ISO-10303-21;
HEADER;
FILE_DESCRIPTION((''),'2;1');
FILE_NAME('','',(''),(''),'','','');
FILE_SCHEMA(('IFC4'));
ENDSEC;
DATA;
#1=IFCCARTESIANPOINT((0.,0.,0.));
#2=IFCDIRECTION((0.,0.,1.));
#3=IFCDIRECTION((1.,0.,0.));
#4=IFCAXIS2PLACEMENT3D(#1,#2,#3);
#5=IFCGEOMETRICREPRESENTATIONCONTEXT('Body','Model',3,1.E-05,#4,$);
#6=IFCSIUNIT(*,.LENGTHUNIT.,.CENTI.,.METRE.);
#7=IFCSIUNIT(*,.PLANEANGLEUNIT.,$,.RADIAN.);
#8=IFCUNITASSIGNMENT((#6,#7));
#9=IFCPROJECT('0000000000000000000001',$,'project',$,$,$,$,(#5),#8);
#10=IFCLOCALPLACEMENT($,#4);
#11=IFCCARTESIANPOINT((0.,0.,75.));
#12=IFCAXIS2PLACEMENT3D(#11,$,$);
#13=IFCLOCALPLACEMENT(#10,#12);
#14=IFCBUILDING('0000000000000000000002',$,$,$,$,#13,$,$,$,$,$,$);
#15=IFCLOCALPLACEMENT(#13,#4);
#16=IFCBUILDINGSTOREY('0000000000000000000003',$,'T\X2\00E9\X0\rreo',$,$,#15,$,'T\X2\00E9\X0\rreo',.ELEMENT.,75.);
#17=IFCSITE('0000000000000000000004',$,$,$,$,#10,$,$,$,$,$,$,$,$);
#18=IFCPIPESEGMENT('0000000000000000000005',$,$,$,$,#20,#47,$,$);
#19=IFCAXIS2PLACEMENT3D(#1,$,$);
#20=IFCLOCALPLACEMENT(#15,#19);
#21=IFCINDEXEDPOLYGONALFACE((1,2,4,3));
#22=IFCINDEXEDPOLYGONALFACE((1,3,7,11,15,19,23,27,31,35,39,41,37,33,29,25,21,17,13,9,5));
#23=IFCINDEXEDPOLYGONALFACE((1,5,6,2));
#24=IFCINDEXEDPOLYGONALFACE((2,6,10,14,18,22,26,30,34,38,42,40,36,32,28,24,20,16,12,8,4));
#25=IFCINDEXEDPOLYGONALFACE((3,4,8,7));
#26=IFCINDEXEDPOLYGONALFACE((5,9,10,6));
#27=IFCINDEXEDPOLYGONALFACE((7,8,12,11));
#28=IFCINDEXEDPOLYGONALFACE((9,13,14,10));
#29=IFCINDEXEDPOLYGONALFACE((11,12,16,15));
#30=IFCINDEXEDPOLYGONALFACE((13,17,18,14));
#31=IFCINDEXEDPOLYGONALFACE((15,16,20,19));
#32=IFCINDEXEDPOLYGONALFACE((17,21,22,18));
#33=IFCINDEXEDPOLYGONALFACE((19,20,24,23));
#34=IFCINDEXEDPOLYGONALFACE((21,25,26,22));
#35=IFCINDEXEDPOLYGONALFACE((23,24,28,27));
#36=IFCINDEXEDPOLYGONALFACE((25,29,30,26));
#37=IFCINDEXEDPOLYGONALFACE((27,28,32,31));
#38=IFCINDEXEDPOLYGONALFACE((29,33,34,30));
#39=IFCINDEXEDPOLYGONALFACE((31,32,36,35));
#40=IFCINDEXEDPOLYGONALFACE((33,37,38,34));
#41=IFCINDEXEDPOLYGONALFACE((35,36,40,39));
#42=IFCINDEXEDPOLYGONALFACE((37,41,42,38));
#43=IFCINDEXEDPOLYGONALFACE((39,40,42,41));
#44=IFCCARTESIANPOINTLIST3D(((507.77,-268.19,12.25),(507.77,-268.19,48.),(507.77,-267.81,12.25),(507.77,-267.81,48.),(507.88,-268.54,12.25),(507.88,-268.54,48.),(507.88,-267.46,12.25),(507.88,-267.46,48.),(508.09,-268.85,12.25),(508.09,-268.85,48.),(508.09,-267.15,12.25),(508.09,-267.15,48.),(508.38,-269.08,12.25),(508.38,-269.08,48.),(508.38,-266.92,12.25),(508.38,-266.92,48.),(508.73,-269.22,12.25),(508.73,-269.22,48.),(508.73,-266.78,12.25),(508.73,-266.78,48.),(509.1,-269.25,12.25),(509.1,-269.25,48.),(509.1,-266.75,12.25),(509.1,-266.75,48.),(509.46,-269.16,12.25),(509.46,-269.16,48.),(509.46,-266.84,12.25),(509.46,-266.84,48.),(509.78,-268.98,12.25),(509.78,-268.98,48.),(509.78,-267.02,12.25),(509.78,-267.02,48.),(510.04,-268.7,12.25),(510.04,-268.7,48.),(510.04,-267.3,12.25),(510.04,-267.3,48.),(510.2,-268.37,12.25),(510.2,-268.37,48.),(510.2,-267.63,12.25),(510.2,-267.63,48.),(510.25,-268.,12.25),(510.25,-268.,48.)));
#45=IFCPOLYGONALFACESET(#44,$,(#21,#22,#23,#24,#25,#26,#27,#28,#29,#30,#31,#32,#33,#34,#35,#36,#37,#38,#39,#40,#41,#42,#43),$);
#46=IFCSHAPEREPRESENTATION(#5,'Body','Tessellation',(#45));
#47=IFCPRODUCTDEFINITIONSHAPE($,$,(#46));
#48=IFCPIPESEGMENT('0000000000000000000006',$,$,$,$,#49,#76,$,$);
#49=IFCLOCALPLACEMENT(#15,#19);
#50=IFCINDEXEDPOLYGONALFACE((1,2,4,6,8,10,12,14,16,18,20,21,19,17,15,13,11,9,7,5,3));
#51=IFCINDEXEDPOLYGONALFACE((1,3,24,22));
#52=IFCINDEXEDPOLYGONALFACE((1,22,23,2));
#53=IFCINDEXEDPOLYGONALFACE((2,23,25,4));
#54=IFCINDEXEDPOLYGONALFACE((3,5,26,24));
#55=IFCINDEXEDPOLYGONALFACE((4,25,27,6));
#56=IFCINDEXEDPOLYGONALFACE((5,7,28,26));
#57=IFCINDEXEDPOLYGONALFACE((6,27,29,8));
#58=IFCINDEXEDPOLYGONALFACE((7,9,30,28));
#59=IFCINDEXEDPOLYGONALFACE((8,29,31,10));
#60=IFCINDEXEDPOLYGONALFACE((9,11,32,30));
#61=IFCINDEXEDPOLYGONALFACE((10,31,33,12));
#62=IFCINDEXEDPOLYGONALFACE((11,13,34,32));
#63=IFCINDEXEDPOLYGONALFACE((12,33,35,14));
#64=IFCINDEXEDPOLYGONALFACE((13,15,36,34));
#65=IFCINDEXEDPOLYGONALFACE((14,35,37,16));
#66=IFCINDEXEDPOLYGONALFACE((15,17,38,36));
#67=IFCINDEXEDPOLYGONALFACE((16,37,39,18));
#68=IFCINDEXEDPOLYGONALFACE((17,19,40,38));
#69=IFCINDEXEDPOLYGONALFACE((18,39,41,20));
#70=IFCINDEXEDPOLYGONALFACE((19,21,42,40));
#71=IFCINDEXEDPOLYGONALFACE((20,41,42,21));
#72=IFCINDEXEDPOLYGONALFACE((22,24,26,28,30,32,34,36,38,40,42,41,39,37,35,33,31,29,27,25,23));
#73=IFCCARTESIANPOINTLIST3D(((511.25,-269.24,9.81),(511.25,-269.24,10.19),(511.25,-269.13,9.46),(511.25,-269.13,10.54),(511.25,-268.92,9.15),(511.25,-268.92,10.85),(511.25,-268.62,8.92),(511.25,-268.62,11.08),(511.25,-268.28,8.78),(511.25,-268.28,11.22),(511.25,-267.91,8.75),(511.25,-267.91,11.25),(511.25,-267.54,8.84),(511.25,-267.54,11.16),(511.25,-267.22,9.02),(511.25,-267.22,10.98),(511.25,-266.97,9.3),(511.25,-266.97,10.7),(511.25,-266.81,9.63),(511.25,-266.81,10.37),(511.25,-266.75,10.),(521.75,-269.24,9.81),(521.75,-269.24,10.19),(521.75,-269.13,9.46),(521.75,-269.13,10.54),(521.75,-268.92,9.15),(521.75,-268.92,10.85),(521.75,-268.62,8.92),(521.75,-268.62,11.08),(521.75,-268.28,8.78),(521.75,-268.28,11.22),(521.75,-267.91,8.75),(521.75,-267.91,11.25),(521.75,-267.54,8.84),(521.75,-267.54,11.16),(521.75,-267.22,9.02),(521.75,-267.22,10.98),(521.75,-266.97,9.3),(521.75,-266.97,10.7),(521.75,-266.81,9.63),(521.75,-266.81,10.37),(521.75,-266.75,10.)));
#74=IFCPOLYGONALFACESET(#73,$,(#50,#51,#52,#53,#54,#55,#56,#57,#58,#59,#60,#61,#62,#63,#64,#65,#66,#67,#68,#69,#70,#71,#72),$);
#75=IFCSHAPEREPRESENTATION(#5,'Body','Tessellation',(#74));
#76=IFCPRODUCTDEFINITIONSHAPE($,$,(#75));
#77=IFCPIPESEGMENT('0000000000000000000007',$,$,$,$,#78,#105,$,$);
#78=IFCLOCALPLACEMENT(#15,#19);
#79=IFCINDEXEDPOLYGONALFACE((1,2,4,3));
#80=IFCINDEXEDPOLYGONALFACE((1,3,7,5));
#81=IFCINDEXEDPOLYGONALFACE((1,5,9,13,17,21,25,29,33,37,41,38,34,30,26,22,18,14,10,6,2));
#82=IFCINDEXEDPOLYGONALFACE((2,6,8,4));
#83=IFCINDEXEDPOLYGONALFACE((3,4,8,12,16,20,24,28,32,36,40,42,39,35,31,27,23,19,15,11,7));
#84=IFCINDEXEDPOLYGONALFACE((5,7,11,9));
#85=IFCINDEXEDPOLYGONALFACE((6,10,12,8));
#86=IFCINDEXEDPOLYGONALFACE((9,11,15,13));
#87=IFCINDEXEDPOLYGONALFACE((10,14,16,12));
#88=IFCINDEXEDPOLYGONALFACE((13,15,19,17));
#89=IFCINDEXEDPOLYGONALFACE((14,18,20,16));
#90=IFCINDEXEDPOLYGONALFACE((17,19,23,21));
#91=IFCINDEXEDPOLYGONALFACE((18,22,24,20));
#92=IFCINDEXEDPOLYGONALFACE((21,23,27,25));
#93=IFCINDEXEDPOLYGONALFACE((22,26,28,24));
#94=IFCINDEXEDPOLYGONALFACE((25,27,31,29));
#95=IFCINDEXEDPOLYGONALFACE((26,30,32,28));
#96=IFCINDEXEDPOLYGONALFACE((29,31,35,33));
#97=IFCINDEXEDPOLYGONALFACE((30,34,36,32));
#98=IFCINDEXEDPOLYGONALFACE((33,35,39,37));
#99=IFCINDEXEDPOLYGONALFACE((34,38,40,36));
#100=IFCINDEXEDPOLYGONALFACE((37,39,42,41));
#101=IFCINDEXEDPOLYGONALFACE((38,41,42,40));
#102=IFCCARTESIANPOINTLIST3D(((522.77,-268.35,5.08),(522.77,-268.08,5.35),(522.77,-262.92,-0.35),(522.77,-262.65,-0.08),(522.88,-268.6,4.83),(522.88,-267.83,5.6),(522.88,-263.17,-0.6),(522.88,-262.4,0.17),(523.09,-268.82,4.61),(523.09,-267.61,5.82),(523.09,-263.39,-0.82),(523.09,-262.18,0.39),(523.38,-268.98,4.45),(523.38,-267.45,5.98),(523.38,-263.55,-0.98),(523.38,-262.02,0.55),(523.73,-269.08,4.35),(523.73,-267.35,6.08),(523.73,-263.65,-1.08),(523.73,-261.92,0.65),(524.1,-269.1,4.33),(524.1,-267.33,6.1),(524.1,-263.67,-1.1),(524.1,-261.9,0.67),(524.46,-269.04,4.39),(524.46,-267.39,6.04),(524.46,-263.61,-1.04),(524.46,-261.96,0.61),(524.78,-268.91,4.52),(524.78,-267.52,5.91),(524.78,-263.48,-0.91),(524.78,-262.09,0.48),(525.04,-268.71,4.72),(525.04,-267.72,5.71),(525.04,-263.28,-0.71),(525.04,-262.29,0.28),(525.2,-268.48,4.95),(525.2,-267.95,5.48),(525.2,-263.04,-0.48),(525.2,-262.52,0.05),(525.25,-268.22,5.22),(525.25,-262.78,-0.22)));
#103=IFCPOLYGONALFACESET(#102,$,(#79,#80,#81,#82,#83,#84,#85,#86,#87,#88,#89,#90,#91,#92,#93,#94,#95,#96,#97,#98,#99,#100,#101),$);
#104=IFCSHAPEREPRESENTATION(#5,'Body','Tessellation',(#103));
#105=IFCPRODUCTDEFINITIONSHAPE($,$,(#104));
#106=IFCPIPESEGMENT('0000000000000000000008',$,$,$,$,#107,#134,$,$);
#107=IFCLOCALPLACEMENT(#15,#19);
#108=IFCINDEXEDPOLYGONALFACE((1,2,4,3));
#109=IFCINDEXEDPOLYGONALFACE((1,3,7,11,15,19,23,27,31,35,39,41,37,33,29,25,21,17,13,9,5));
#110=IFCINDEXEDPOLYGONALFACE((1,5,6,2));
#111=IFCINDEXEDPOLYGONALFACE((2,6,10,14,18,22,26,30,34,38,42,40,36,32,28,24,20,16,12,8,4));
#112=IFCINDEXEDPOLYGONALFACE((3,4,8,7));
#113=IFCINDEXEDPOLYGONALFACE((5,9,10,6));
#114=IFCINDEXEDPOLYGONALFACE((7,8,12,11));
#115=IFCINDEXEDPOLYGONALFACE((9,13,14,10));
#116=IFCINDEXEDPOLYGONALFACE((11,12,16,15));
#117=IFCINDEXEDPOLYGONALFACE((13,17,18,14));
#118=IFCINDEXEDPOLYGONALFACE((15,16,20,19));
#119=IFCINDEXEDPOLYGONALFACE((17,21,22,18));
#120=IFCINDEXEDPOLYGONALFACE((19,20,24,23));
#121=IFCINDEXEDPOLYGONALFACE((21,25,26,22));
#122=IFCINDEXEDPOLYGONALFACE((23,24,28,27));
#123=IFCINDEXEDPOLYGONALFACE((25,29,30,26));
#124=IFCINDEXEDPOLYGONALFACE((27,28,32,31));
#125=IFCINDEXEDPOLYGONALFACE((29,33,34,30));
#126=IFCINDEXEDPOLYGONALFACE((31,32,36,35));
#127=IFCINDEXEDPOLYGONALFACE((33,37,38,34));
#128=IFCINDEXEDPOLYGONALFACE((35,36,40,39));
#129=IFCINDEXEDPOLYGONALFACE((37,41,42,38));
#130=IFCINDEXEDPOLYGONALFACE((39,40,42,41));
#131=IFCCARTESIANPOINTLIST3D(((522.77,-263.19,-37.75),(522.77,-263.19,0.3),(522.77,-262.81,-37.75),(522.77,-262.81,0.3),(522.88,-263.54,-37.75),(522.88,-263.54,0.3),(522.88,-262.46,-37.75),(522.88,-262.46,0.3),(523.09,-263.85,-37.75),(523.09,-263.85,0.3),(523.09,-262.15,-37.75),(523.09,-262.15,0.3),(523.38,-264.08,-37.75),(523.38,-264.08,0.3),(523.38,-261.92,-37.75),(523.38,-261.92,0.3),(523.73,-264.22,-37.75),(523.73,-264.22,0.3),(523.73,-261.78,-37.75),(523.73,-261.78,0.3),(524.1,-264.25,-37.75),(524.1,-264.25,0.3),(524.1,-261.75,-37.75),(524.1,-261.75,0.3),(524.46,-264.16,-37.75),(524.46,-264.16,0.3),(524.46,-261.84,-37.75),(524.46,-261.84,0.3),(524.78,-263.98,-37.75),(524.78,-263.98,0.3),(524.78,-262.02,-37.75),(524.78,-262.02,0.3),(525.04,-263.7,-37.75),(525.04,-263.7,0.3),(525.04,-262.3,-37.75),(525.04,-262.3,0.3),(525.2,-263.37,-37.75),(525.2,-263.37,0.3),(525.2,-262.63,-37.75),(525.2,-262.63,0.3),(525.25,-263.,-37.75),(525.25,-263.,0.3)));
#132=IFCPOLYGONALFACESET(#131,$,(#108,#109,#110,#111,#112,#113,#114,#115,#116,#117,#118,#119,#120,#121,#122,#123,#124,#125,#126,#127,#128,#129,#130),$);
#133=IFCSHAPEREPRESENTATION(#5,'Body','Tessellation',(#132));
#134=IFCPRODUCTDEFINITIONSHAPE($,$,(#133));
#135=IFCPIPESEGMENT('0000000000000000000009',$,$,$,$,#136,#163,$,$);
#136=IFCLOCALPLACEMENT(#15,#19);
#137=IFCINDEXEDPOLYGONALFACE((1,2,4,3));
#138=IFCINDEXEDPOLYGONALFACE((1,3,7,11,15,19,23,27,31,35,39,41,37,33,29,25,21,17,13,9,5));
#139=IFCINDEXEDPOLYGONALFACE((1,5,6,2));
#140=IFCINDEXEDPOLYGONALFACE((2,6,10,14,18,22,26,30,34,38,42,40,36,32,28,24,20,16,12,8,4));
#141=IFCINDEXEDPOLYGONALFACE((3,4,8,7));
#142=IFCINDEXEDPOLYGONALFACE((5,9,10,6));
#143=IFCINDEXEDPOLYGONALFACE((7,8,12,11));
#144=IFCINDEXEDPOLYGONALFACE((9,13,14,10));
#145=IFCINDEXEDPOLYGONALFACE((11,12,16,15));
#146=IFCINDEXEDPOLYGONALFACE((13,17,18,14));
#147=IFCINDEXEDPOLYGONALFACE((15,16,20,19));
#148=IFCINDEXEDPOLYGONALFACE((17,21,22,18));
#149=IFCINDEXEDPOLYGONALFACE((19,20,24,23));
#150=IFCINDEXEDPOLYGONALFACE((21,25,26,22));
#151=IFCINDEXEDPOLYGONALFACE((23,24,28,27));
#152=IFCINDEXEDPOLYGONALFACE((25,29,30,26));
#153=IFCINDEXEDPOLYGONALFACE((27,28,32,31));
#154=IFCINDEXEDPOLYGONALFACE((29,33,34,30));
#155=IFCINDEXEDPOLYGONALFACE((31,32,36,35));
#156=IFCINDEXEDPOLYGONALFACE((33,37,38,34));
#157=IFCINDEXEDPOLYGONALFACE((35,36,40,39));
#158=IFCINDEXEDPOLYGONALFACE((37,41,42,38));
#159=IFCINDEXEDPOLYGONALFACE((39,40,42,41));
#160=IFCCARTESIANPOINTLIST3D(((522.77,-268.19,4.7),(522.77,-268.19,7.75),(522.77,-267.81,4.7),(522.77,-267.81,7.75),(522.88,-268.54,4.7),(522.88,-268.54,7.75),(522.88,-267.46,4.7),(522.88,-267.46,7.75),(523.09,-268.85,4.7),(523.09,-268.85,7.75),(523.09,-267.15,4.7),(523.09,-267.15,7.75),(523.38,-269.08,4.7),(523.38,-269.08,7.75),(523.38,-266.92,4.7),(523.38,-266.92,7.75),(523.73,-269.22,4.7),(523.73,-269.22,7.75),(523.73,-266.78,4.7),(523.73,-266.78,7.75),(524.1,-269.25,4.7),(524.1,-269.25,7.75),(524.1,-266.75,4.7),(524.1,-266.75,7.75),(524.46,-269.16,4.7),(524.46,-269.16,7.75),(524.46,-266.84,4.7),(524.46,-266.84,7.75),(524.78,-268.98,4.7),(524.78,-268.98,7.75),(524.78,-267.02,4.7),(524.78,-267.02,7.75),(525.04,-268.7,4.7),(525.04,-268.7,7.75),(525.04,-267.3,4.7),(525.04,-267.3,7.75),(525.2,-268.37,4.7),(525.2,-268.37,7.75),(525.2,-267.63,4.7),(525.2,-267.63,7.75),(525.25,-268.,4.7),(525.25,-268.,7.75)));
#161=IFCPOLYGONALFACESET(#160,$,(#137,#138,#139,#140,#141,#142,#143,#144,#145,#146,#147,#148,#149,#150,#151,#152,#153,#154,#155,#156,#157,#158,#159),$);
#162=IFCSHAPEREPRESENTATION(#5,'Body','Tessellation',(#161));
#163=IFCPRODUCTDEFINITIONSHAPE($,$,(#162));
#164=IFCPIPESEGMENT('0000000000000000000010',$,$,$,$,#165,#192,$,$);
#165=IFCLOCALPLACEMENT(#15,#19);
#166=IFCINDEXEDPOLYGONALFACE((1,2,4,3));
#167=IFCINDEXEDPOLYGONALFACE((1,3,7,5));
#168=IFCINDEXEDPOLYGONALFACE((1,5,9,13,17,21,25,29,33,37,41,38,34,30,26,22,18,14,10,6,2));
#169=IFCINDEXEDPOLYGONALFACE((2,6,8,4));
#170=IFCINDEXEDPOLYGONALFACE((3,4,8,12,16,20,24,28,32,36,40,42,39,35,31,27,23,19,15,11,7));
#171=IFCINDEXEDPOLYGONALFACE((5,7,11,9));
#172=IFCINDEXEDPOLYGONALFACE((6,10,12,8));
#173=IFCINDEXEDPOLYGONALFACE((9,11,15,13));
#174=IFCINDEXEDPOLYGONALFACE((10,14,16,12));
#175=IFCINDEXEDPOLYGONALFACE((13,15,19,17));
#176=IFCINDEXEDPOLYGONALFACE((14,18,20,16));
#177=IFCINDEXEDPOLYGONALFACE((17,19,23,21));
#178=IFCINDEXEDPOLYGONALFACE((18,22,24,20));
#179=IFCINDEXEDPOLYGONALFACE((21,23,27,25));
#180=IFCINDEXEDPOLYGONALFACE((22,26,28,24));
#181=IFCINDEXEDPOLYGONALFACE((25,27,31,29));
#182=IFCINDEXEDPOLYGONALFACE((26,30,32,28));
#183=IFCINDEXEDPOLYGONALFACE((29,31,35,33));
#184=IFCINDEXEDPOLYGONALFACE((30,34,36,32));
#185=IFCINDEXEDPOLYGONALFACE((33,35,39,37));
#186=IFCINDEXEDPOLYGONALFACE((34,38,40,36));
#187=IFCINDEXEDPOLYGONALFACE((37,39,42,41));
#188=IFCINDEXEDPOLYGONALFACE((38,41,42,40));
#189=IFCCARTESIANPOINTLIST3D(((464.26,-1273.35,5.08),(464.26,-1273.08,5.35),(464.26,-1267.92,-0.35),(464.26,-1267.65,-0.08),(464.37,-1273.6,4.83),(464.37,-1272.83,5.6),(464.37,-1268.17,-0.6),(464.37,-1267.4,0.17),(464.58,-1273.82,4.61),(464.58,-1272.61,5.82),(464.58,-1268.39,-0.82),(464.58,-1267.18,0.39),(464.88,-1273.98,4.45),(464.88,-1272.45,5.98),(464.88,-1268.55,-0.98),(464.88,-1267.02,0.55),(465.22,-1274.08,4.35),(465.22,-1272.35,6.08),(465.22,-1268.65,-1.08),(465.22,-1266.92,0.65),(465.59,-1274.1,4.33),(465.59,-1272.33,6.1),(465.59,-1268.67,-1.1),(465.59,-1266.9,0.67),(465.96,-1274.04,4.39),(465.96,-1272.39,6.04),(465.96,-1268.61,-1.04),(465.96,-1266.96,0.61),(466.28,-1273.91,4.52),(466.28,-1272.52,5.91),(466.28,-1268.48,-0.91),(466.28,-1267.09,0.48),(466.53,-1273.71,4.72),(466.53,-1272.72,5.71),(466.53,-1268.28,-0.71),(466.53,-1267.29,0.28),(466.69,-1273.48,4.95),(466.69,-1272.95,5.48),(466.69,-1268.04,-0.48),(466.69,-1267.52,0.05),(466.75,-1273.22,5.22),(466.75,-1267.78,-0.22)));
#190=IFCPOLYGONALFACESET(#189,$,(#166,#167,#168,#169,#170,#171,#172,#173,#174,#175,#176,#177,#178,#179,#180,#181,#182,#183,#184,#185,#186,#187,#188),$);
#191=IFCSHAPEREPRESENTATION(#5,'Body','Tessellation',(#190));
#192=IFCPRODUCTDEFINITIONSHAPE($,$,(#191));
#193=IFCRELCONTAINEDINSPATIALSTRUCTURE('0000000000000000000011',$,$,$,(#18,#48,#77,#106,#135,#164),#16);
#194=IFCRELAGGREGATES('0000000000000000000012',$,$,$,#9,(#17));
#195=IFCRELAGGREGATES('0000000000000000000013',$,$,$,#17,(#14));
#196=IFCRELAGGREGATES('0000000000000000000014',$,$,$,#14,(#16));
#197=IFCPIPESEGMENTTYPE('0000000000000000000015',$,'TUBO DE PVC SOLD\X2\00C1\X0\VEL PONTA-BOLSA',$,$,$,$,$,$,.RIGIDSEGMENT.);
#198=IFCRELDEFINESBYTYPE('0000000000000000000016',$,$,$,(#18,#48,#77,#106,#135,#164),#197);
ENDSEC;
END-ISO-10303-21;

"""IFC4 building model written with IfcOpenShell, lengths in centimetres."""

from ifc_helpers import new_model, si_unit, frame, origin_with_axes, origin_2d_with_axis, place, context, project, spatial, circle, extrude, type_object, element, save


model = new_model("IFC4")

# Units and contexts
model_context = context("Model", 3, precision=1e-05, world=origin_with_axes(), identifier="Body")
ifc_project = project(units=[si_unit("LENGTHUNIT", "METRE", prefix="CENTI"), si_unit("PLANEANGLEUNIT", "RADIAN")], contexts=[model_context])

# Site, building, storey
site_placement = place(None, origin_with_axes())
site = spatial("IfcSite", under=ifc_project, at=site_placement)
building_placement = place(site_placement, frame((0.0, 0.0, 75.0)))
building = spatial("IfcBuilding", under=site, at=building_placement)
storey_placement = place(building_placement, origin_with_axes())
storey = spatial("IfcBuildingStorey", under=building, at=storey_placement, Name="Térreo", LongName="Térreo", CompositionType="ELEMENT", Elevation=75.0)

# Pipe segments
pipe_segment_type_1 = type_object("IfcPipeSegmentType", Name="TUBO DE PVC SOLDÁVEL PONTA-BOLSA", PredefinedType="RIGIDSEGMENT")
pipe_segment_1_placement = place(storey_placement, frame((509.0, -268.0, 48.0), z_axis=(0.0, 0.0, 1.0), x_axis=(1.0, 0.0, 0.0)))
element("IfcPipeSegment", 1, at=pipe_segment_1_placement, inside=storey, type_object=pipe_segment_type_1, context=model_context, shape_type="SolidModel", body=[
    extrude(circle(Radius=1.25, at=origin_2d_with_axis()), frame((0.0, 0.0, -35.75), z_axis=(0.0, 0.0, 1.0), x_axis=(1.0, 0.0, 0.0)), (0.0, 0.0, 1.0), 35.75),
])
pipe_segment_2_placement = place(storey_placement, frame((516.5, -268.0, 11.25), z_axis=(0.0, 0.0, 1.0), x_axis=(1.0, 0.0, 0.0)))
element("IfcPipeSegment", 2, at=pipe_segment_2_placement, inside=storey, type_object=pipe_segment_type_1, context=model_context, shape_type="SolidModel", body=[
    extrude(circle(Radius=1.25, at=origin_2d_with_axis()), frame((5.25, 0.0, -1.25), z_axis=(-1.0, 0.0, 0.0), x_axis=(0.0, 1.0, 0.0)), (0.0, 0.0, 1.0), 10.5),
])
pipe_segment_3_placement = place(storey_placement, frame((524.0, -265.5, 6.1), z_axis=(0.0, 0.0, 1.0), x_axis=(1.0, 0.0, 0.0)))
element("IfcPipeSegment", 3, at=pipe_segment_3_placement, inside=storey, type_object=pipe_segment_type_1, context=model_context, shape_type="SolidModel", body=[
    extrude(circle(Radius=1.25, at=origin_2d_with_axis()), frame((0.0, 2.72, -6.31), z_axis=(0.0, -0.707107, 0.707107), x_axis=(1.0, 0.0, 0.0)), (0.0, 0.0, 1.0), 7.68),
])
pipe_segment_4_placement = place(storey_placement, frame((524.0, -263.0, 0.3), z_axis=(0.0, 0.0, 1.0), x_axis=(1.0, 0.0, 0.0)))
element("IfcPipeSegment", 4, at=pipe_segment_4_placement, inside=storey, type_object=pipe_segment_type_1, context=model_context, shape_type="SolidModel", body=[
    extrude(circle(Radius=1.25, at=origin_2d_with_axis()), frame((0.0, 0.0, -38.05), z_axis=(0.0, 0.0, 1.0), x_axis=(1.0, 0.0, 0.0)), (0.0, 0.0, 1.0), 38.05),
])
pipe_segment_5_placement = place(storey_placement, frame((524.0, -268.0, 7.75), z_axis=(0.0, 0.0, 1.0), x_axis=(1.0, 0.0, 0.0)))
element("IfcPipeSegment", 5, at=pipe_segment_5_placement, inside=storey, type_object=pipe_segment_type_1, context=model_context, shape_type="SolidModel", body=[
    extrude(circle(Radius=1.25, at=origin_2d_with_axis()), frame((0.0, 0.0, -3.05), z_axis=(0.0, 0.0, 1.0), x_axis=(1.0, 0.0, 0.0)), (0.0, 0.0, 1.0), 3.05),
])
pipe_segment_6_placement = place(storey_placement, frame((465.5, -1270.5, 6.1), z_axis=(0.0, 0.0, 1.0), x_axis=(1.0, 0.0, 0.0)))
element("IfcPipeSegment", 6, at=pipe_segment_6_placement, inside=storey, type_object=pipe_segment_type_1, context=model_context, shape_type="SolidModel", body=[
    extrude(circle(Radius=1.25, at=origin_2d_with_axis()), frame((0.0, 2.72, -6.31), z_axis=(0.0, -0.707107, 0.707107), x_axis=(1.0, 0.0, 0.0)), (0.0, 0.0, 1.0), 7.68),
])

save(model, "model.ifc")
